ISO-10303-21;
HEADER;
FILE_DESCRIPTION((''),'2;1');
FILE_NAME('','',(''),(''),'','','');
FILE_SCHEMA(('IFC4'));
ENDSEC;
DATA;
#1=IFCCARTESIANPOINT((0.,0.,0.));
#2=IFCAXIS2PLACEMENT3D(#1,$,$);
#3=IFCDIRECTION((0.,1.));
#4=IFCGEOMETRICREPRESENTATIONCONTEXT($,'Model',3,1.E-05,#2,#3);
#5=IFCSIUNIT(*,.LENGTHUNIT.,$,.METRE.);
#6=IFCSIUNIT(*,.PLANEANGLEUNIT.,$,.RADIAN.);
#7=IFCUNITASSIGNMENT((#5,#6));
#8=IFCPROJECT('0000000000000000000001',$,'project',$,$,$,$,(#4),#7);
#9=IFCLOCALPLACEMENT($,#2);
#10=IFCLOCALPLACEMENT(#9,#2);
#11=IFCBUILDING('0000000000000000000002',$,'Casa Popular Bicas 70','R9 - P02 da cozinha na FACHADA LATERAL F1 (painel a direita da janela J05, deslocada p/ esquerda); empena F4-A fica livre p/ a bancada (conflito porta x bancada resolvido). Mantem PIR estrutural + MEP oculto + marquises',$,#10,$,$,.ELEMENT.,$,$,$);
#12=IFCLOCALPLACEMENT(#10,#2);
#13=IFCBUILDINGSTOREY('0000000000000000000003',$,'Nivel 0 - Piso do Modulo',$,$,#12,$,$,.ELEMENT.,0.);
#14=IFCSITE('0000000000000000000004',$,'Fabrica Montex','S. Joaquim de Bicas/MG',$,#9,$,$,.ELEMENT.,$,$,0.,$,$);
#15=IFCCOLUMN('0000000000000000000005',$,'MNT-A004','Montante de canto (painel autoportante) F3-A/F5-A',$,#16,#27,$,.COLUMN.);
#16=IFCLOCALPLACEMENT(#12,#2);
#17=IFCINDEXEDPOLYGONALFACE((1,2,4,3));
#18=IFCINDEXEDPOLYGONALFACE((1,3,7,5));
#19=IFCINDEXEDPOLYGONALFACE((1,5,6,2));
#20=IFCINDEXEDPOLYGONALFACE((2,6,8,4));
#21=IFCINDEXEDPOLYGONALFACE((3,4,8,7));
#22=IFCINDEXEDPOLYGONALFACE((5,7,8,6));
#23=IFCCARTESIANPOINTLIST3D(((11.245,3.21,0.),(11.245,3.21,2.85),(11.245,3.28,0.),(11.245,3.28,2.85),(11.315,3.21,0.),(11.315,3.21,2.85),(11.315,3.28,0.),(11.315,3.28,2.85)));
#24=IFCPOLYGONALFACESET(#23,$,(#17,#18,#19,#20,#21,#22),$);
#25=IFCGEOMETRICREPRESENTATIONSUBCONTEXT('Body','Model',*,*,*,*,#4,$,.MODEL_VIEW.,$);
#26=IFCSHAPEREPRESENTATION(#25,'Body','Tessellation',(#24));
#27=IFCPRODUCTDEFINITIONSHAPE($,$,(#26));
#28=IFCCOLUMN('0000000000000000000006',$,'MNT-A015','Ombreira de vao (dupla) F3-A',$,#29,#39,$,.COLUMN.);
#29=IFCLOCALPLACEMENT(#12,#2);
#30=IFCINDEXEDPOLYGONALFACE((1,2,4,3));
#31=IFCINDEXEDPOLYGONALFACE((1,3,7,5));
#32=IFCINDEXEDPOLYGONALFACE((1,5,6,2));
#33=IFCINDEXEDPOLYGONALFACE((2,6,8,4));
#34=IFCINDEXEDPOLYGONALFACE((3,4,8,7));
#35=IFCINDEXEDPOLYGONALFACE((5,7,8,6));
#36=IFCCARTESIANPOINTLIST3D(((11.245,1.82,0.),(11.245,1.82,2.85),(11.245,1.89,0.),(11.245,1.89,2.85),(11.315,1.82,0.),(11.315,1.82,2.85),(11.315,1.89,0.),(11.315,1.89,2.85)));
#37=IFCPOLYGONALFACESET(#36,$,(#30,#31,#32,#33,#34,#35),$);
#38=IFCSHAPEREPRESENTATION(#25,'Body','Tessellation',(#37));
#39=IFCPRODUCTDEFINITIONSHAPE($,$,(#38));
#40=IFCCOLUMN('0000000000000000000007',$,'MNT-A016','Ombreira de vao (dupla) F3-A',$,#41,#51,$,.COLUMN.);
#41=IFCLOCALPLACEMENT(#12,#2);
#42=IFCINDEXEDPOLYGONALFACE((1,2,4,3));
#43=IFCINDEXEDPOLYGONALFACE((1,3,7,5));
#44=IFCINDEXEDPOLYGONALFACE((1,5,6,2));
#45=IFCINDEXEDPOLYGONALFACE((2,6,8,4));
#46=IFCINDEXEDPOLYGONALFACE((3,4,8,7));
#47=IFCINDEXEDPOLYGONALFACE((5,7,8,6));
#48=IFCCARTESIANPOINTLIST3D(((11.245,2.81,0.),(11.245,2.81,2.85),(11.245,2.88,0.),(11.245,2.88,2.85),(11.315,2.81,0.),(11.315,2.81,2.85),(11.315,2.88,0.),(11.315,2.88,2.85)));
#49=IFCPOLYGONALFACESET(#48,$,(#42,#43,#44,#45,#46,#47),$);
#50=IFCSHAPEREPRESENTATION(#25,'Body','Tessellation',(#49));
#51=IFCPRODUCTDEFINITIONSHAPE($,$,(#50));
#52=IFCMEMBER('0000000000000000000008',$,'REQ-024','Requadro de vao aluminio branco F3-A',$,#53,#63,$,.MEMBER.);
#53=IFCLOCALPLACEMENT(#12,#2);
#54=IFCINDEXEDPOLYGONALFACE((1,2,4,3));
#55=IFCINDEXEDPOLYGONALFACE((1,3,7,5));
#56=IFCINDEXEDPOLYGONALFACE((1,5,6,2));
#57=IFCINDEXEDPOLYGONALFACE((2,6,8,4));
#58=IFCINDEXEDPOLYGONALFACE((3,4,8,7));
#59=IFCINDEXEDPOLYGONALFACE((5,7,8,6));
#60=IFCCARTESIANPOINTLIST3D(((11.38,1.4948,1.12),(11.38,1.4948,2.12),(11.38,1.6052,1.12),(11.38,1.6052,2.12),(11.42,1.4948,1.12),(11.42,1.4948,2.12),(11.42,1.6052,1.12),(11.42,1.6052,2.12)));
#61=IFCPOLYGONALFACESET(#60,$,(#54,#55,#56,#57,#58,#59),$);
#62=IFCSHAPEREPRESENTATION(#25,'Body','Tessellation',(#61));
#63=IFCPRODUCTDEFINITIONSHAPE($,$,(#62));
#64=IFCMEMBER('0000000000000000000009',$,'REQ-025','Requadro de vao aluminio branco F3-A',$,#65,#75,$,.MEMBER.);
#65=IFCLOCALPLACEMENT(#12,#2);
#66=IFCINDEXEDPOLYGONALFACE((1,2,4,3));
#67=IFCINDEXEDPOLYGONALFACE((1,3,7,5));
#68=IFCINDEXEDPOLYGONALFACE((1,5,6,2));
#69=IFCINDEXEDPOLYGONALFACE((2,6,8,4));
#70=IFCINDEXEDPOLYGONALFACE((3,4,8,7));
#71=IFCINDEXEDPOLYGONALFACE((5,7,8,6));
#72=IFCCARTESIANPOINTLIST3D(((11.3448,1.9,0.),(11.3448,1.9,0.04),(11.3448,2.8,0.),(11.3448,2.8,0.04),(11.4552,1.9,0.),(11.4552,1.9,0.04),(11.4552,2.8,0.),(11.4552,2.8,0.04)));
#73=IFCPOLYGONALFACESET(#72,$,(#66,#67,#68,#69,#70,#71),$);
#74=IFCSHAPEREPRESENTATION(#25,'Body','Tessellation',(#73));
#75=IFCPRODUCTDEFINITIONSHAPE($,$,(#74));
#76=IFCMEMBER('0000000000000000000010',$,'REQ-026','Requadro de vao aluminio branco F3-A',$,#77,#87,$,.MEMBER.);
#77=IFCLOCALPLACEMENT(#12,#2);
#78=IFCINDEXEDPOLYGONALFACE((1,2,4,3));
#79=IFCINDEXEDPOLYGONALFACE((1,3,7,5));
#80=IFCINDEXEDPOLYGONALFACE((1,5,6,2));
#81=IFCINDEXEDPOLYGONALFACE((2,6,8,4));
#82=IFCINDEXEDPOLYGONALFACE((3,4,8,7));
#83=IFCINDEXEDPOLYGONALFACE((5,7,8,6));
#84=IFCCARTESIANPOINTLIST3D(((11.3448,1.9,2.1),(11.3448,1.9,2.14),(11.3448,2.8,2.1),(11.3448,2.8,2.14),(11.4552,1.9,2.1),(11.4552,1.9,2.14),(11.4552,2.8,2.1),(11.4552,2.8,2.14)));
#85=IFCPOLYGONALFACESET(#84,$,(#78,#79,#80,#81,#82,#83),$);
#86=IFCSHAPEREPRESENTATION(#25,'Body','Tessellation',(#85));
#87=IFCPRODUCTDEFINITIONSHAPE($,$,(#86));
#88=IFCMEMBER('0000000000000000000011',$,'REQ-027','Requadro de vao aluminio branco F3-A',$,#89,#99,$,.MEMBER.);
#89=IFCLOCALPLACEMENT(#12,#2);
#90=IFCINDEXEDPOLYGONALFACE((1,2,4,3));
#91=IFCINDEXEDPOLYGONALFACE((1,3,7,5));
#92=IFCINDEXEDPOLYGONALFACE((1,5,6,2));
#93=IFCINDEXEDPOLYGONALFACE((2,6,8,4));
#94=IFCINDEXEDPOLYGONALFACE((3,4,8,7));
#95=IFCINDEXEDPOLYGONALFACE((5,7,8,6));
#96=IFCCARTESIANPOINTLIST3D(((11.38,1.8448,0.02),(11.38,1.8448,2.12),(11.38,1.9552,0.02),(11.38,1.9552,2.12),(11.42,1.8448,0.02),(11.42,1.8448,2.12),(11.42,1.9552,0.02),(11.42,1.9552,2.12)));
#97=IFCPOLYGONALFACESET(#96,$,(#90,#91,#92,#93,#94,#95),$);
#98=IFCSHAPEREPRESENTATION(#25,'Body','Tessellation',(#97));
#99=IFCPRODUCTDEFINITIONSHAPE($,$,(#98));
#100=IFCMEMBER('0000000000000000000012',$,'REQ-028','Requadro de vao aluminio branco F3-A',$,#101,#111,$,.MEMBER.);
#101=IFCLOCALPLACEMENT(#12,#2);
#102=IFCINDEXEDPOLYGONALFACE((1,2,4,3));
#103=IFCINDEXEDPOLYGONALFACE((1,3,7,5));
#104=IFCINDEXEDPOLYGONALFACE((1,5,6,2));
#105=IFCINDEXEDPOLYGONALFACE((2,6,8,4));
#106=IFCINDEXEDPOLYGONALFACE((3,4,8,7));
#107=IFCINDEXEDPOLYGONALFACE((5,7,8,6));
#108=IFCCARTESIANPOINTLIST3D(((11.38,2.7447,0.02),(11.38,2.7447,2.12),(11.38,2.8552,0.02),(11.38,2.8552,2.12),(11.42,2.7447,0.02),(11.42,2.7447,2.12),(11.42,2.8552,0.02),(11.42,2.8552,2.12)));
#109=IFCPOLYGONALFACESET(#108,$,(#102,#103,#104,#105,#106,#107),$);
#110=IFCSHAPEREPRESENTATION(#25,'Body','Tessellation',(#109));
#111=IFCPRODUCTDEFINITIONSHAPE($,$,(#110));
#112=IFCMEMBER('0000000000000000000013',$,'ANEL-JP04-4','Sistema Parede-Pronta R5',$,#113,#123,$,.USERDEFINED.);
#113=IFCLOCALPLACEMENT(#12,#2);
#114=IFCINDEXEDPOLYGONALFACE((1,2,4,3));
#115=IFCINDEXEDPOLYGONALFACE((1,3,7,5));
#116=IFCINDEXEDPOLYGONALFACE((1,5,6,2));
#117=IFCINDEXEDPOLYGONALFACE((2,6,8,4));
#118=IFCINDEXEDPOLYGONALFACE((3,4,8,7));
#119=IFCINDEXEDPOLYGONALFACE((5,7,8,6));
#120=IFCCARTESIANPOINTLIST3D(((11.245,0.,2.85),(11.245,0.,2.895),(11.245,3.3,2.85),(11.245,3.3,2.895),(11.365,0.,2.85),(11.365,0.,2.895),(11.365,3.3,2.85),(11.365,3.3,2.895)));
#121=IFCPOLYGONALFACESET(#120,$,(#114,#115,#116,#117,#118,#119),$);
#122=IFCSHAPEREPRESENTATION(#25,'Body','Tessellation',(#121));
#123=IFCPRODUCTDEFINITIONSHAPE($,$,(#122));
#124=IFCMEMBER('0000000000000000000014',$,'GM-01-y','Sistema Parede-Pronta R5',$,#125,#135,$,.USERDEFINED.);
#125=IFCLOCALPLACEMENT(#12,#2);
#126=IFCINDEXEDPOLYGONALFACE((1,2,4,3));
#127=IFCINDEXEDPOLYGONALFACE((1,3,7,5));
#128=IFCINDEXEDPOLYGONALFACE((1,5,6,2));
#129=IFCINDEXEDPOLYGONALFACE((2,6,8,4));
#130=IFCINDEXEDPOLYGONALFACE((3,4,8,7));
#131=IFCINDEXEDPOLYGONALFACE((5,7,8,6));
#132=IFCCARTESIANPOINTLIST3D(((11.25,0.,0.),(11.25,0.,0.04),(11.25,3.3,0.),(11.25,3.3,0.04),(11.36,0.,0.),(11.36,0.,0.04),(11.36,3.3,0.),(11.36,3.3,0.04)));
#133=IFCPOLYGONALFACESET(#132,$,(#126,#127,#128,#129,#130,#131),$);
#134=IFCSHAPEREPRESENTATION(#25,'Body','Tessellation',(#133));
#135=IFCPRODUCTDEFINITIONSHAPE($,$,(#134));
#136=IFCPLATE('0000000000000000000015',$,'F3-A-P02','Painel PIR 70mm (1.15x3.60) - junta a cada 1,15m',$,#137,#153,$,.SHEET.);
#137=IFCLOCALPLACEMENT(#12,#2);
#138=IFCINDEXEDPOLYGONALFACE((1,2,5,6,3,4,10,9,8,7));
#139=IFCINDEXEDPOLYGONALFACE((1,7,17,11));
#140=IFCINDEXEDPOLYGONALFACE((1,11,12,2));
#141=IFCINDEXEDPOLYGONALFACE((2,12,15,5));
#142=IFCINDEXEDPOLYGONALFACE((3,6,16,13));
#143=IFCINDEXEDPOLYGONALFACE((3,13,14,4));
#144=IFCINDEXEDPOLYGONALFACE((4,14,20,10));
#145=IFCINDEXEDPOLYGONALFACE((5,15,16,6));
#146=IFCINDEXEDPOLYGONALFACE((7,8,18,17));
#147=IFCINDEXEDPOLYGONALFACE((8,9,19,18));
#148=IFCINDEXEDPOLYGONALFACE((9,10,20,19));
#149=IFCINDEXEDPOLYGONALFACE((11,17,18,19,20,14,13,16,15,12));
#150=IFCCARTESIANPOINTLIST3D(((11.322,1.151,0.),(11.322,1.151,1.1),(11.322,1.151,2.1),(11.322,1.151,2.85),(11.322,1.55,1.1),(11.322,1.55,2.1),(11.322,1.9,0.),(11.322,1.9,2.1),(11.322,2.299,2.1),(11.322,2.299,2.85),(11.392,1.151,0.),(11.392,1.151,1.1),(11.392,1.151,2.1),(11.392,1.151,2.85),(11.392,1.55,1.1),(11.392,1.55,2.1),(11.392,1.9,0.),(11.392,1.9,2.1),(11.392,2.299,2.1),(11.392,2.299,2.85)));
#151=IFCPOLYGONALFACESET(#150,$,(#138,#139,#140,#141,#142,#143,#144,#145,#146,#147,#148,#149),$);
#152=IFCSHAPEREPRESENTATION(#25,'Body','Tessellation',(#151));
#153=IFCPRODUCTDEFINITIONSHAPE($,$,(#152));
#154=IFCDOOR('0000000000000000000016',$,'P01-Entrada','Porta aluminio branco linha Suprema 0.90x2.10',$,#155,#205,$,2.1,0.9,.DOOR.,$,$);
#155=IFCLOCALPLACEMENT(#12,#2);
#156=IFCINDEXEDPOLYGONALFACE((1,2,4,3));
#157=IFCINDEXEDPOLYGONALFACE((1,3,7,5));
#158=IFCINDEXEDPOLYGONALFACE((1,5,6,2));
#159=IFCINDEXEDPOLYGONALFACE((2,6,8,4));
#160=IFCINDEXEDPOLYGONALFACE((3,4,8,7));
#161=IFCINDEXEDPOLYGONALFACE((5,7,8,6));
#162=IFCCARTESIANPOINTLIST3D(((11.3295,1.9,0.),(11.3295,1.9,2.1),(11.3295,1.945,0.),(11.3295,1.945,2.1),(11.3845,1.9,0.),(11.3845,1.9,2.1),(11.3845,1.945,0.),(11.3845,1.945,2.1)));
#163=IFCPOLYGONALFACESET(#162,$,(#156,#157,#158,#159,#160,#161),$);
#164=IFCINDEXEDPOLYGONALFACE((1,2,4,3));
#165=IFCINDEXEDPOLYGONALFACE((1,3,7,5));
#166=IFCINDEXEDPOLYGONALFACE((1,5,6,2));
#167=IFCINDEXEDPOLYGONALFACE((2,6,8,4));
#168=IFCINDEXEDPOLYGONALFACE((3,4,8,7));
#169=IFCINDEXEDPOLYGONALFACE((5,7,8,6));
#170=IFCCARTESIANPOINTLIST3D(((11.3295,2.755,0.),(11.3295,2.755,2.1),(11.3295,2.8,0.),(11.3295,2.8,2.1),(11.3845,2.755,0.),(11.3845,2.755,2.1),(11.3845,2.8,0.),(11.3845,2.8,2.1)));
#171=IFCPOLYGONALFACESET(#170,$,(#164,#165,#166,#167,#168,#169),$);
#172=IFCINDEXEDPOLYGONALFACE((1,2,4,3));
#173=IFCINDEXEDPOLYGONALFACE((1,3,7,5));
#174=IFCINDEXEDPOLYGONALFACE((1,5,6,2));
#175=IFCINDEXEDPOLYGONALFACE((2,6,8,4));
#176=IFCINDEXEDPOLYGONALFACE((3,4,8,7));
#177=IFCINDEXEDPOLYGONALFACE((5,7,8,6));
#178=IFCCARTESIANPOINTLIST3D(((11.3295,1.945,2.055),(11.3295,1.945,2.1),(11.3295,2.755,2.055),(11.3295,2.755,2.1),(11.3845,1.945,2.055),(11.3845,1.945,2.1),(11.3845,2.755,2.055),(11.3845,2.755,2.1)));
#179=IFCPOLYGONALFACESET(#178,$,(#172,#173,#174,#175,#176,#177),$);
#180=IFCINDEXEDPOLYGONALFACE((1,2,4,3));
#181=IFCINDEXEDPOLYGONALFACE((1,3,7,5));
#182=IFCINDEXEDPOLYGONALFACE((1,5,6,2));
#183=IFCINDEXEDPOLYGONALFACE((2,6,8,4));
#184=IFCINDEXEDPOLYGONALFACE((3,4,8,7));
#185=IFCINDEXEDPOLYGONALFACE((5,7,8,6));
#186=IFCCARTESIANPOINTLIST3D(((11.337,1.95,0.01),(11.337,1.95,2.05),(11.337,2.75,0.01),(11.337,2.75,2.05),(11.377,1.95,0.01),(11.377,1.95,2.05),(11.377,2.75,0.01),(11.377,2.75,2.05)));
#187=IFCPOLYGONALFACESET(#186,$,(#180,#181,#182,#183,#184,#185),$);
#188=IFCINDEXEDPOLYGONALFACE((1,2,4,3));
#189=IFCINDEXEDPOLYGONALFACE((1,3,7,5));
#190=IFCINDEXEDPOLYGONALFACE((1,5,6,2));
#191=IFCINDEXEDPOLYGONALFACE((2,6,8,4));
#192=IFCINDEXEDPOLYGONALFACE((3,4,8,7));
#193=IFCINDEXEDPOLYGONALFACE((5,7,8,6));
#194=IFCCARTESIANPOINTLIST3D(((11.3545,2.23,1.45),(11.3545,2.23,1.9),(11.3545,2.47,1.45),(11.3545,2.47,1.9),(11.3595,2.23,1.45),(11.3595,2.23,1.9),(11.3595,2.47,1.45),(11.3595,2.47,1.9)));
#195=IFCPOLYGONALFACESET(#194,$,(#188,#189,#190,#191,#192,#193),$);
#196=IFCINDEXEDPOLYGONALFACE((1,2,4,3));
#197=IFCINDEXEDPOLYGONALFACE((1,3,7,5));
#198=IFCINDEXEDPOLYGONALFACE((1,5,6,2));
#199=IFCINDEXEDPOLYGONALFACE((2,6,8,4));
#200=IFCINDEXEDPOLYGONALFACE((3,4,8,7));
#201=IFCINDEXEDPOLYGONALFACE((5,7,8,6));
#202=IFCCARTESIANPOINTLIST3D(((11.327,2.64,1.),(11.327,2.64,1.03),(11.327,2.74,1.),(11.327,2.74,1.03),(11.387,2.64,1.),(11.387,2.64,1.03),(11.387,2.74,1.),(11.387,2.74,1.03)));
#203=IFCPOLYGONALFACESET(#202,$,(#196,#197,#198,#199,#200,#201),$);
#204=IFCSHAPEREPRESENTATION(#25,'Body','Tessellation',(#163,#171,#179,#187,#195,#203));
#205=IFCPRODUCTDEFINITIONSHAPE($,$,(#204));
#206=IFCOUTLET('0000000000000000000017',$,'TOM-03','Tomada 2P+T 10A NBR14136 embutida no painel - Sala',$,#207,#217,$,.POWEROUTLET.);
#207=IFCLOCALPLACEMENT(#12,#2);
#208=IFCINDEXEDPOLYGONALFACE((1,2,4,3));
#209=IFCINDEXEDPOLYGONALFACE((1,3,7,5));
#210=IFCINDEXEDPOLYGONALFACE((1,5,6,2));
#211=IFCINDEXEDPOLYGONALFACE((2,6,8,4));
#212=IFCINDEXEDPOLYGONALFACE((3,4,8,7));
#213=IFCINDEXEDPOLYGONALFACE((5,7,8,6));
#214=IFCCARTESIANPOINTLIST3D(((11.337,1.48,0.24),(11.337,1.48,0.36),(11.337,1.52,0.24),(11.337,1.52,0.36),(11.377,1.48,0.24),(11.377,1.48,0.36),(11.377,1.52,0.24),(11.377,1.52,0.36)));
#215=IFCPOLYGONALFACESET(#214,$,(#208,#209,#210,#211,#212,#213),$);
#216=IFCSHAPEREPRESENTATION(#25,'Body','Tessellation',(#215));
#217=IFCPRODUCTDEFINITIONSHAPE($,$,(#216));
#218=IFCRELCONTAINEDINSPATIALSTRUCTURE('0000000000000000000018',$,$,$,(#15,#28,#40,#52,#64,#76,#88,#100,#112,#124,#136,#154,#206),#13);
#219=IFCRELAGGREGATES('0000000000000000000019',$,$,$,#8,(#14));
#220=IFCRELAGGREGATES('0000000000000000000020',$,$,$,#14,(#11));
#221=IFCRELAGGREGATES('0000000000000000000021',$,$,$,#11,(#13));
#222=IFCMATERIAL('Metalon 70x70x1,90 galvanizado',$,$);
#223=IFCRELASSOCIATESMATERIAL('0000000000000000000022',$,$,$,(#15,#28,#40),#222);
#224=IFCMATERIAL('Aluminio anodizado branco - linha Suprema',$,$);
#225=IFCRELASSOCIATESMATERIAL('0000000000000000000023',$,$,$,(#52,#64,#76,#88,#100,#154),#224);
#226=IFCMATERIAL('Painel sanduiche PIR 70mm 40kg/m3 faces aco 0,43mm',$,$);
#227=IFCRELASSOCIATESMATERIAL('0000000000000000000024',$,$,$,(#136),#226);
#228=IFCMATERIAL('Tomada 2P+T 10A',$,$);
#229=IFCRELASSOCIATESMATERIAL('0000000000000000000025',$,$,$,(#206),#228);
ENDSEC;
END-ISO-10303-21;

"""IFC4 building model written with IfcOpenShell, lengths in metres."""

from ifc_helpers import new_model, si_unit, direction, frame, frame_2d, origin, origin_2d, place, context, subcontext, project, spatial, rectangle, extrude, material, element, fill, save


model = new_model("IFC4")

# Units and contexts
model_context = context("Model", 3, precision=1e-05, world=origin(), true_north=direction((0.0, 1.0)))
body_context = subcontext(model_context, "Body", "Model", "MODEL_VIEW")
ifc_project = project(units=[si_unit("LENGTHUNIT", "METRE"), si_unit("PLANEANGLEUNIT", "RADIAN")], contexts=[model_context])

# Site, building, storey
site_placement = place(None, origin())
site = spatial("IfcSite", under=ifc_project, at=site_placement, Name="Fabrica Montex", Description="S. Joaquim de Bicas/MG", CompositionType="ELEMENT", RefElevation=0.0)
building_placement = place(site_placement, origin())
building = spatial("IfcBuilding", under=site, at=building_placement, Name="Casa Popular Bicas 70", Description="R9 - P02 da cozinha na FACHADA LATERAL F1 (painel a direita da janela J05, deslocada p/ esquerda); empena F4-A fica livre p/ a bancada (conflito porta x bancada resolvido). Mantem PIR estrutural + MEP oculto + marquises", CompositionType="ELEMENT")
storey_placement = place(building_placement, origin())
storey = spatial("IfcBuildingStorey", under=building, at=storey_placement, Name="Nivel 0 - Piso do Modulo", CompositionType="ELEMENT", Elevation=0.0)

# Columns
ifc_material_1 = material(Name="Metalon 70x70x1,90 galvanizado")
for number, where, name, description in (
    (1, (11.28, 3.245, 0.0), "MNT-A004", "Montante de canto (painel autoportante) F3-A/F5-A"),
    (2, (11.28, 1.855, 0.0), "MNT-A015", "Ombreira de vao (dupla) F3-A"),
    (3, (11.28, 2.845, 0.0), "MNT-A016", "Ombreira de vao (dupla) F3-A"),
):
    element("IfcColumn", number, at=place(storey_placement, frame(where)), inside=storey, material=ifc_material_1, Name=name, Description=description, PredefinedType="COLUMN", context=body_context, shape_type="SweptSolid", body=[
        extrude(rectangle(XDim=0.07, YDim=0.07, at=origin_2d()), origin(), (0.0, 0.0, 1.0), 2.85),
    ])

# Members
ifc_material_2 = material(Name="Aluminio anodizado branco - linha Suprema")
member_1_placement = place(storey_placement, frame((11.4, 1.55, 1.12), z_axis=(0.0, 0.0, 1.0), x_axis=(1.0, 0.0, 0.0)))
element("IfcMember", 4, at=member_1_placement, inside=storey, material=ifc_material_2, Name="REQ-024", Description="Requadro de vao aluminio branco F3-A", PredefinedType="MEMBER", context=body_context, shape_type="SweptSolid", body=[
    extrude(rectangle(XDim=0.04, YDim=0.1105, at=origin_2d()), origin(), (0.0, 0.0, 1.0), 1.0),
])
for number, where, z_axis, x_axis, name in (
    (5, (11.4, 1.9, 0.02), (0.0, 1.0, 0.0), (0.0, 0.0, 1.0), "REQ-025"),
    (6, (11.4, 1.9, 2.12), (0.0, 1.0, 0.0), (0.0, 0.0, 1.0), "REQ-026"),
):
    element("IfcMember", number, at=place(storey_placement, frame(where, z_axis=z_axis, x_axis=x_axis)), inside=storey, material=ifc_material_2, Name=name, Description="Requadro de vao aluminio branco F3-A", PredefinedType="MEMBER", context=body_context, shape_type="SweptSolid", body=[
        extrude(rectangle(XDim=0.04, YDim=0.1105, at=origin_2d()), origin(), (0.0, 0.0, 1.0), 0.9),
    ])
for number, where, z_axis, x_axis, name in (
    (7, (11.4, 1.9, 0.02), (0.0, 0.0, 1.0), (1.0, 0.0, 0.0), "REQ-027"),
    (8, (11.4, 2.8, 0.02), (0.0, 0.0, 1.0), (1.0, 0.0, 0.0), "REQ-028"),
):
    element("IfcMember", number, at=place(storey_placement, frame(where, z_axis=z_axis, x_axis=x_axis)), inside=storey, material=ifc_material_2, Name=name, Description="Requadro de vao aluminio branco F3-A", PredefinedType="MEMBER", context=body_context, shape_type="SweptSolid", body=[
        extrude(rectangle(XDim=0.04, YDim=0.1105, at=origin_2d()), origin(), (0.0, 0.0, 1.0), 2.1),
    ])
member_2_placement = place(storey_placement, frame((11.305, 1.65, 2.85)))
element("IfcMember", 9, at=member_2_placement, inside=storey, Name="ANEL-JP04-4", Description="Sistema Parede-Pronta R5", PredefinedType="USERDEFINED", context=body_context, shape_type="SweptSolid", body=[
    extrude(rectangle(XDim=0.12, YDim=3.3, at=origin_2d()), origin(), (0.0, 0.0, 1.0), 0.045),
])
member_3_placement = place(storey_placement, frame((11.305, 1.65, 0.0)))
element("IfcMember", 10, at=member_3_placement, inside=storey, Name="GM-01-y", Description="Sistema Parede-Pronta R5", PredefinedType="USERDEFINED", context=body_context, shape_type="SweptSolid", body=[
    extrude(rectangle(XDim=0.11, YDim=3.3, at=origin_2d()), origin(), (0.0, 0.0, 1.0), 0.04),
])

# Plate, openings, door
ifc_material_3 = material(Name="Painel sanduiche PIR 70mm 40kg/m3 faces aco 0,43mm")
plate_1_placement = place(storey_placement, frame((11.357, 1.151, 0.0), x_axis=(0.0, 1.0, 0.0)))
plate_1 = element("IfcPlate", 11, at=plate_1_placement, inside=storey, material=ifc_material_3, Name="F3-A-P02", Description="Painel PIR 70mm (1.15x3.60) - junta a cada 1,15m", PredefinedType="SHEET", context=body_context, shape_type="SweptSolid", body=[
    extrude(rectangle(XDim=1.148, YDim=0.07, at=frame_2d((0.574, 0.0))), origin(), (0.0, 0.0, 1.0), 2.85),
])
opening_1_placement = place(storey_placement, frame((11.357, 1.35, 1.1)))
element("IfcOpeningElement", 12, at=opening_1_placement, cuts=plate_1, PredefinedType="OPENING", context=body_context, shape_type="SweptSolid", body=[
    extrude(rectangle(XDim=0.1, YDim=0.4, at=origin_2d()), origin(), (0.0, 0.0, 1.0), 1.0),
])
opening_2_placement = place(storey_placement, frame((11.357, 2.1, 0.0)))
opening_2 = element("IfcOpeningElement", 13, at=opening_2_placement, cuts=plate_1, PredefinedType="OPENING", context=body_context, shape_type="SweptSolid", body=[
    extrude(rectangle(XDim=0.1, YDim=0.4, at=origin_2d()), origin(), (0.0, 0.0, 1.0), 2.1),
])
door_placement = place(storey_placement, frame((11.357, 1.9, 0.0), x_axis=(0.0, 1.0, 0.0)))
door = element("IfcDoor", 14, at=door_placement, inside=storey, material=ifc_material_2, Name="P01-Entrada", Description="Porta aluminio branco linha Suprema 0.90x2.10", OverallHeight=2.1, OverallWidth=0.9, PredefinedType="DOOR", context=body_context, shape_type="SweptSolid", body=[
    extrude(rectangle(XDim=0.045, YDim=0.055, at=frame_2d((0.0225, 0.0))), origin(), (0.0, 0.0, 1.0), 2.1),
    extrude(rectangle(XDim=0.045, YDim=0.055, at=frame_2d((0.8775, 0.0))), origin(), (0.0, 0.0, 1.0), 2.1),
    extrude(rectangle(XDim=0.81, YDim=0.055, at=frame_2d((0.45, 0.0))), frame((0.0, 0.0, 2.055)), (0.0, 0.0, 1.0), 0.045),
    extrude(rectangle(XDim=0.8, YDim=0.04, at=frame_2d((0.45, 0.0))), frame((0.0, 0.0, 0.01)), (0.0, 0.0, 1.0), 2.04),
    extrude(rectangle(XDim=0.24, YDim=0.005, at=frame_2d((0.45, 0.0))), frame((0.0, 0.0, 1.45)), (0.0, 0.0, 1.0), 0.45),
    extrude(rectangle(XDim=0.1, YDim=0.06, at=frame_2d((0.79, 0.0))), frame((0.0, 0.0, 1.0)), (0.0, 0.0, 1.0), 0.03),
])
fill(opening_2, door)

# Outlet
ifc_material_4 = material(Name="Tomada 2P+T 10A")
outlet_placement = place(storey_placement, frame((11.337, 1.48, 0.24)))
element("IfcOutlet", 15, at=outlet_placement, inside=storey, material=ifc_material_4, Name="TOM-03", Description="Tomada 2P+T 10A NBR14136 embutida no painel - Sala", PredefinedType="POWEROUTLET", context=body_context, shape_type="SweptSolid", body=[
    extrude(rectangle(XDim=0.04, YDim=0.04, at=frame_2d((0.02, 0.02))), origin(), (0.0, 0.0, 1.0), 0.12),
])

save(model, "model.ifc")
